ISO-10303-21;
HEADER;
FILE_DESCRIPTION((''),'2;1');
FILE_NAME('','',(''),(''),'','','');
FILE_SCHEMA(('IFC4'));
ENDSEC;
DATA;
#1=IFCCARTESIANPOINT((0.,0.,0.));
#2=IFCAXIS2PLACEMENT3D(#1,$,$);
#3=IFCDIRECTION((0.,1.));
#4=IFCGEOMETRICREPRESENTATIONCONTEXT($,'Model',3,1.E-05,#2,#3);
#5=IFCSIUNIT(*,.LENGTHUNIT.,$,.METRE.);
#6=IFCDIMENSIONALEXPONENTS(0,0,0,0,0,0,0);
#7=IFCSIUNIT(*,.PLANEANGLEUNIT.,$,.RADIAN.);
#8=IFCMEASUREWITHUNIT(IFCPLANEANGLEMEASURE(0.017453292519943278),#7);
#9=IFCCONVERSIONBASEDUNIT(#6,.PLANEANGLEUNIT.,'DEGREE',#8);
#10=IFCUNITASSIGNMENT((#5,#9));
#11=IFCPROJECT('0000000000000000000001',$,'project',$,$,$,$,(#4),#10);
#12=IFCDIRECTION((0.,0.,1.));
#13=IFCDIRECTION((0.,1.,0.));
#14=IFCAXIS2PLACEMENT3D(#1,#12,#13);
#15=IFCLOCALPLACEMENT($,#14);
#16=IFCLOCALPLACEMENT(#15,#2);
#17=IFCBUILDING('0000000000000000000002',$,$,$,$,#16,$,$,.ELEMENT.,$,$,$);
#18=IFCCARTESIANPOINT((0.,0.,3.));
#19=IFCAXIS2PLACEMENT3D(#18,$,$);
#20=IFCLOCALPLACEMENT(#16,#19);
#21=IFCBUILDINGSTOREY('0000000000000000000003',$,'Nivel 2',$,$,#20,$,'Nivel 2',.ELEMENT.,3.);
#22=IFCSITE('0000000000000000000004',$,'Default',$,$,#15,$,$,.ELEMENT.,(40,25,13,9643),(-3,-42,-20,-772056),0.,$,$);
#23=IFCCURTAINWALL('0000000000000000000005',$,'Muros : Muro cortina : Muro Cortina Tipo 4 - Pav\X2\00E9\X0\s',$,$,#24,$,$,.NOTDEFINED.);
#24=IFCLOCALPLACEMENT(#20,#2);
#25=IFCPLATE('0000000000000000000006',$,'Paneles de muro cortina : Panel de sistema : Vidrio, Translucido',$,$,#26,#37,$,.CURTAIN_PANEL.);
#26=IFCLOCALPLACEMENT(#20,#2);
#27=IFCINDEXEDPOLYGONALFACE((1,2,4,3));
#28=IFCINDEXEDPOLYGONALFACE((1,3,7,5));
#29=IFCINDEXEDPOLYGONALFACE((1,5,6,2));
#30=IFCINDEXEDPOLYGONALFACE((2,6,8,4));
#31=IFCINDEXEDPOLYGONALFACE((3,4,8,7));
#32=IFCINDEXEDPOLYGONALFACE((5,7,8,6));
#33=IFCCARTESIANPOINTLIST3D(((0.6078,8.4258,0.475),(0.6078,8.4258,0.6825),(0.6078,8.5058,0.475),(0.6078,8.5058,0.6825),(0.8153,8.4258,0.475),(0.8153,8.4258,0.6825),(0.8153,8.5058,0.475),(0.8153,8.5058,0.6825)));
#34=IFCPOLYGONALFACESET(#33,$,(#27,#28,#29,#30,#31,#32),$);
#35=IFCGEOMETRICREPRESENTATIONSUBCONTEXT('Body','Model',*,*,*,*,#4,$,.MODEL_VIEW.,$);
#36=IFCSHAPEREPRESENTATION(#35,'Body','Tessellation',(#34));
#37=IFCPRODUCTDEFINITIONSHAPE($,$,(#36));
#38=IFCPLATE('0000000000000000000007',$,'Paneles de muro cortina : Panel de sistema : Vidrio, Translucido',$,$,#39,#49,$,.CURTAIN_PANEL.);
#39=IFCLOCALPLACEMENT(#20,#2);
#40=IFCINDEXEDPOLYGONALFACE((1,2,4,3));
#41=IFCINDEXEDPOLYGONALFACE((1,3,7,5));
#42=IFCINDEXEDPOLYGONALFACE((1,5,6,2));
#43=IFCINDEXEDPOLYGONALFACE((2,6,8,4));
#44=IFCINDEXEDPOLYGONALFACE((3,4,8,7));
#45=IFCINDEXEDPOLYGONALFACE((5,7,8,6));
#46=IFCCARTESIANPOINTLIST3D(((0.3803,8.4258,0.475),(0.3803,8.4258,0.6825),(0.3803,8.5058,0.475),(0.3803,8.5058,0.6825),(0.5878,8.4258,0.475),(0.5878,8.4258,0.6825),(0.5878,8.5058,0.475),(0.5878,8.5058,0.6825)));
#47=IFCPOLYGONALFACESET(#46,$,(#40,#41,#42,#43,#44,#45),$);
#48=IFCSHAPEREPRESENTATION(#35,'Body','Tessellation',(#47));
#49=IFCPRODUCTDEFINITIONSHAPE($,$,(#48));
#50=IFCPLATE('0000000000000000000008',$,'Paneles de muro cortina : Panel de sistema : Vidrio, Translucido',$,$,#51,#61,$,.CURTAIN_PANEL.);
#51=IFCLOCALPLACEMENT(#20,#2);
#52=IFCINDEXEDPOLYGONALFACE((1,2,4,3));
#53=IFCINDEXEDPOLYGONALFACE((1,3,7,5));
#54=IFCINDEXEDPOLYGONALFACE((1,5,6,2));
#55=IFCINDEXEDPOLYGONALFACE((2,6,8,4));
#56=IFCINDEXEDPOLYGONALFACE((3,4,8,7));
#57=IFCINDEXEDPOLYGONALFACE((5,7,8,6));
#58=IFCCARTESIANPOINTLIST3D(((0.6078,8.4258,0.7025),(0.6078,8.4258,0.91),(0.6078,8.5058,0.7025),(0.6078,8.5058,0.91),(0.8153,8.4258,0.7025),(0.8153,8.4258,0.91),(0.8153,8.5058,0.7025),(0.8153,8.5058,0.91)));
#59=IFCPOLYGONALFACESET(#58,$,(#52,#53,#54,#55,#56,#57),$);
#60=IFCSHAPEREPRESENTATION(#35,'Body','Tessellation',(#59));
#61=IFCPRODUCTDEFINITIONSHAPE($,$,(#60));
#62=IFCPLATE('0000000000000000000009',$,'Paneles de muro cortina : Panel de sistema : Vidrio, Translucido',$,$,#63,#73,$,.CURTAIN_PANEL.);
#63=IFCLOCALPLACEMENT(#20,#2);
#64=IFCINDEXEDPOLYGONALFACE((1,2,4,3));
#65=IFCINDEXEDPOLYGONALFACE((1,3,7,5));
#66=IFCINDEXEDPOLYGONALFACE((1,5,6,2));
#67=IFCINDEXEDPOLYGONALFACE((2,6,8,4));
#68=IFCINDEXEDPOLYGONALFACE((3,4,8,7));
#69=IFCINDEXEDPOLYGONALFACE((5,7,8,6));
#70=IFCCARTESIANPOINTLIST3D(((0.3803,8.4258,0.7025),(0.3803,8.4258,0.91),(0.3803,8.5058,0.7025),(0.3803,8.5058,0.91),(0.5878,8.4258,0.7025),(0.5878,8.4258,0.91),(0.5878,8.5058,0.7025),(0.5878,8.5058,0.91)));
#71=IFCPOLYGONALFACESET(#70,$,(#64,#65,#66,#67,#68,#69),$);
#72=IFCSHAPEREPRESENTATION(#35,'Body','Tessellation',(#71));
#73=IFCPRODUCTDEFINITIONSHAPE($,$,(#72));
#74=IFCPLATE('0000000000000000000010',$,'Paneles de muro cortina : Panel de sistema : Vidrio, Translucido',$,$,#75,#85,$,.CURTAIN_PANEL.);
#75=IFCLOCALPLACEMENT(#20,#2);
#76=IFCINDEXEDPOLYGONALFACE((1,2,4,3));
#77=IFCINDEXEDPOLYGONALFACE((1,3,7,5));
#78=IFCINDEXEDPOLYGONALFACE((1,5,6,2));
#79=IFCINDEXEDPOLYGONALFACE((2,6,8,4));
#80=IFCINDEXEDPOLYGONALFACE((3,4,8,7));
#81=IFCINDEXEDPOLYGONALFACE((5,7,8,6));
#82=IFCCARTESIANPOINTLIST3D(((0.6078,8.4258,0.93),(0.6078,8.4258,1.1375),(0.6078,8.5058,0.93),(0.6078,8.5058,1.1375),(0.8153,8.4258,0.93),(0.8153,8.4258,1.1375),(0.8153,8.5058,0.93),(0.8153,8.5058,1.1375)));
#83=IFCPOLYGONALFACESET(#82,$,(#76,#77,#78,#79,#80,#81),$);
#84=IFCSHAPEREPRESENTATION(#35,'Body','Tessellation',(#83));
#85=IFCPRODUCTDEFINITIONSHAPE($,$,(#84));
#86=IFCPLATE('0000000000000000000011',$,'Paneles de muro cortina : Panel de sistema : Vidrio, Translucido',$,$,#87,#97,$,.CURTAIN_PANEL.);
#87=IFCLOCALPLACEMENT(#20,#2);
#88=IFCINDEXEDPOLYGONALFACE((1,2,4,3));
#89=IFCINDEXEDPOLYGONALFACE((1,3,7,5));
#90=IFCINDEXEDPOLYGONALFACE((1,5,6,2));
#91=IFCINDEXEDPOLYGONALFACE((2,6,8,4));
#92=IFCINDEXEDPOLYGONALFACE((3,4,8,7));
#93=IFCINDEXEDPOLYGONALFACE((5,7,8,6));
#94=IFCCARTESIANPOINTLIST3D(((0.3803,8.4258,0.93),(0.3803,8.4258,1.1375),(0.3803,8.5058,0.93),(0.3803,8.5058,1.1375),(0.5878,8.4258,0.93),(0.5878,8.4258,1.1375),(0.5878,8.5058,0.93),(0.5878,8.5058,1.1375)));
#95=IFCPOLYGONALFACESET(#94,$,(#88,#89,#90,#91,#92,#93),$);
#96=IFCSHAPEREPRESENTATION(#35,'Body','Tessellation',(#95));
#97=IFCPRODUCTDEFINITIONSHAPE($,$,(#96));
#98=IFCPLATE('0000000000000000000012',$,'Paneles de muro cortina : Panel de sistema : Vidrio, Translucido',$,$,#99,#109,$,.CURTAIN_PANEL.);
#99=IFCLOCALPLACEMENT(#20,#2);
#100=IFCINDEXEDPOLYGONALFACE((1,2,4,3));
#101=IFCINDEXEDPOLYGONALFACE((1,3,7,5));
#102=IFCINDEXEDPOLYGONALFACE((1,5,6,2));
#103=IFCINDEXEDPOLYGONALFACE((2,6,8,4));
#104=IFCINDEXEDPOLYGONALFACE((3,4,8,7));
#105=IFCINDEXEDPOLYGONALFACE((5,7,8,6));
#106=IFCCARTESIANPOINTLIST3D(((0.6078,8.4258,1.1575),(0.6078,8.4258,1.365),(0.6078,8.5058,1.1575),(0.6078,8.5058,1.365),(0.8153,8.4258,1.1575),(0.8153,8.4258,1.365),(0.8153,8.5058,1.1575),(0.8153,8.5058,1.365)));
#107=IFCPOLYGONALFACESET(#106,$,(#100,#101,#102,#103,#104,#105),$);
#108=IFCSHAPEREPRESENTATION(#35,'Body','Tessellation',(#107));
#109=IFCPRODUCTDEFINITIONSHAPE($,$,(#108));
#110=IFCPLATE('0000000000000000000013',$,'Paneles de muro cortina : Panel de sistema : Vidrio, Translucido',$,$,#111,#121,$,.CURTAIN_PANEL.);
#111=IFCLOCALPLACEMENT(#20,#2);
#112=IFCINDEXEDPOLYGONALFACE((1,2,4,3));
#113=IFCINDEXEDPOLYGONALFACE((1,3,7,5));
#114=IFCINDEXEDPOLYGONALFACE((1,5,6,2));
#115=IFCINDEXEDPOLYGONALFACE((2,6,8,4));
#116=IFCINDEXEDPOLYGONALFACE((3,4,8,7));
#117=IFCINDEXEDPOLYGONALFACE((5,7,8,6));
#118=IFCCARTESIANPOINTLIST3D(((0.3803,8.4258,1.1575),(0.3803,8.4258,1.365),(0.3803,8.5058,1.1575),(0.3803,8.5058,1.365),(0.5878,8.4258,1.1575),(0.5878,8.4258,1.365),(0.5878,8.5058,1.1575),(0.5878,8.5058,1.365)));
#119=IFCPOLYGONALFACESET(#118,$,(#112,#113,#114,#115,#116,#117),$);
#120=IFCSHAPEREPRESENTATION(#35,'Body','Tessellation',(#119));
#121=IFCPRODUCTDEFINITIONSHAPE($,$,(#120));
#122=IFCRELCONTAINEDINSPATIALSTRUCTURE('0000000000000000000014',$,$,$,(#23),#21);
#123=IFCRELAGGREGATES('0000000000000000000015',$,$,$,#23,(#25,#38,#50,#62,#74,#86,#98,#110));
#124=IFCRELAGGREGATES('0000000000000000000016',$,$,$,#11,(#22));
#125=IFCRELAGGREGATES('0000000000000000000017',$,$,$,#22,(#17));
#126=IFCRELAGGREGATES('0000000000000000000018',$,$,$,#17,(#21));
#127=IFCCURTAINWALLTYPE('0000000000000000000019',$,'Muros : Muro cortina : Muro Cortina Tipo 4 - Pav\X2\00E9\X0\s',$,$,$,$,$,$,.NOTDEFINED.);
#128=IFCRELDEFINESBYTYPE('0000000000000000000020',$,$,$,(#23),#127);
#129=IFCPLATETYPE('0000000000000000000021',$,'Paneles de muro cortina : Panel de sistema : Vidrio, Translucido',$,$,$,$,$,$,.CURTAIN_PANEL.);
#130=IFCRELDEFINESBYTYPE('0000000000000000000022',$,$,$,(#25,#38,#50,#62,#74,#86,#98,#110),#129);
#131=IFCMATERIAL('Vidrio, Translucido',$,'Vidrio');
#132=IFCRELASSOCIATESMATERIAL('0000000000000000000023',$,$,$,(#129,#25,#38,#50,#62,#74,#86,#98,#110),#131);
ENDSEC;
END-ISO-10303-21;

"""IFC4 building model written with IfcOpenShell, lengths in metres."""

from ifc_helpers import new_model, entity, si_unit, converted_unit, direction, frame, origin, place, context, subcontext, project, spatial, indexed_curve, outline, extrude, source, transform, mapped, material, type_object, type_shapes, element, aggregate, save


model = new_model("IFC4")

# Units and contexts
model_context = context("Model", 3, precision=1e-05, world=origin(), true_north=direction((0.0, 1.0)))
body_context = subcontext(model_context, "Body", "Model", "MODEL_VIEW")
ifc_project = project(units=[si_unit("LENGTHUNIT", "METRE"), converted_unit("PLANEANGLEUNIT", "DEGREE", entity("IfcPlaneAngleMeasure", 0.017453292519943278), si_unit("PLANEANGLEUNIT", "RADIAN"), dimensions=[0, 0, 0, 0, 0, 0, 0])], contexts=[model_context])

# Site, building, storey
site_placement = place(None, frame((0.0, 0.0, 0.0), z_axis=(0.0, 0.0, 1.0), x_axis=(0.0, 1.0, 0.0)))
site = spatial("IfcSite", under=ifc_project, at=site_placement, Name="Default", CompositionType="ELEMENT", RefLatitude=(40, 25, 13, 9643), RefLongitude=(-3, -42, -20, -772056), RefElevation=0.0)
building_placement = place(site_placement, origin())
building = spatial("IfcBuilding", under=site, at=building_placement, CompositionType="ELEMENT")
storey_placement = place(building_placement, frame((0.0, 0.0, 3.0)))
storey = spatial("IfcBuildingStorey", under=building, at=storey_placement, Name="Nivel 2", LongName="Nivel 2", CompositionType="ELEMENT", Elevation=3.0)

# Curtain wall, plates
curtain_wall_type = type_object("IfcCurtainWallType", Name="Muros : Muro cortina : Muro Cortina Tipo 4 - Pavés", PredefinedType="NOTDEFINED")
curtain_wall_placement = place(storey_placement, frame((0.0, 0.0, -3.0)))
curtain_wall = element("IfcCurtainWall", 1, at=curtain_wall_placement, inside=storey, type_object=curtain_wall_type, Name="Muros : Muro cortina : Muro Cortina Tipo 4 - Pavés", PredefinedType="NOTDEFINED")
ifc_material_1 = material(Name="Vidrio, Translucido", Category="Vidrio")
plate_type = type_object("IfcPlateType", Name="Paneles de muro cortina : Panel de sistema : Vidrio, Translucido", PredefinedType="CURTAIN_PANEL", material=ifc_material_1)
shared_shape_1 = source(origin(), body_context, "Body", "SweptSolid", [
    extrude(outline(indexed_curve([(-0.04, -0.1038), (0.04, -0.1038), (0.04, 0.1038), (-0.04, 0.1038), (-0.04, -0.1038)], self_intersect=False)), frame((0.0, 0.0, 0.0), z_axis=(0.0, 0.0, 1.0), x_axis=(0.0, 1.0, 0.0)), (0.0, 0.0, 1.0), 0.2075),
])
type_shapes(plate_type, [shared_shape_1])
plate_1_placement = place(curtain_wall_placement, frame((0.7115, 8.4658, 3.475), z_axis=(0.0, 0.0, 1.0), x_axis=(-1.0, 0.0, 0.0)))
plate_1 = element("IfcPlate", 2, at=plate_1_placement, type_object=plate_type, material=ifc_material_1, Name="Paneles de muro cortina : Panel de sistema : Vidrio, Translucido", PredefinedType="CURTAIN_PANEL", context=body_context, shape_type="MappedRepresentation", body=[
    mapped(shared_shape_1, transform((0.0, 0.0, 0.0), scale=1.0)),
])
plate_2_placement = place(curtain_wall_placement, frame((0.484, 8.4658, 3.475), z_axis=(0.0, 0.0, 1.0), x_axis=(-1.0, 0.0, 0.0)))
plate_2 = element("IfcPlate", 3, at=plate_2_placement, type_object=plate_type, material=ifc_material_1, Name="Paneles de muro cortina : Panel de sistema : Vidrio, Translucido", PredefinedType="CURTAIN_PANEL", context=body_context, shape_type="MappedRepresentation", body=[
    mapped(shared_shape_1, transform((0.0, 0.0, 0.0), scale=1.0)),
])
plate_3_placement = place(curtain_wall_placement, frame((0.7115, 8.4658, 3.7025), z_axis=(0.0, 0.0, 1.0), x_axis=(-1.0, 0.0, 0.0)))
plate_3 = element("IfcPlate", 4, at=plate_3_placement, type_object=plate_type, material=ifc_material_1, Name="Paneles de muro cortina : Panel de sistema : Vidrio, Translucido", PredefinedType="CURTAIN_PANEL", context=body_context, shape_type="MappedRepresentation", body=[
    mapped(shared_shape_1, transform((0.0, 0.0, 0.0), scale=1.0)),
])
plate_4_placement = place(curtain_wall_placement, frame((0.484, 8.4658, 3.7025), z_axis=(0.0, 0.0, 1.0), x_axis=(-1.0, 0.0, 0.0)))
plate_4 = element("IfcPlate", 5, at=plate_4_placement, type_object=plate_type, material=ifc_material_1, Name="Paneles de muro cortina : Panel de sistema : Vidrio, Translucido", PredefinedType="CURTAIN_PANEL", context=body_context, shape_type="MappedRepresentation", body=[
    mapped(shared_shape_1, transform((0.0, 0.0, 0.0), scale=1.0)),
])
plate_5_placement = place(curtain_wall_placement, frame((0.7115, 8.4658, 3.93), z_axis=(0.0, 0.0, 1.0), x_axis=(-1.0, 0.0, 0.0)))
plate_5 = element("IfcPlate", 6, at=plate_5_placement, type_object=plate_type, material=ifc_material_1, Name="Paneles de muro cortina : Panel de sistema : Vidrio, Translucido", PredefinedType="CURTAIN_PANEL", context=body_context, shape_type="MappedRepresentation", body=[
    mapped(shared_shape_1, transform((0.0, 0.0, 0.0), scale=1.0)),
])
plate_6_placement = place(curtain_wall_placement, frame((0.484, 8.4658, 3.93), z_axis=(0.0, 0.0, 1.0), x_axis=(-1.0, 0.0, 0.0)))
plate_6 = element("IfcPlate", 7, at=plate_6_placement, type_object=plate_type, material=ifc_material_1, Name="Paneles de muro cortina : Panel de sistema : Vidrio, Translucido", PredefinedType="CURTAIN_PANEL", context=body_context, shape_type="MappedRepresentation", body=[
    mapped(shared_shape_1, transform((0.0, 0.0, 0.0), scale=1.0)),
])
plate_7_placement = place(curtain_wall_placement, frame((0.7115, 8.4658, 4.1575), z_axis=(0.0, 0.0, 1.0), x_axis=(-1.0, 0.0, 0.0)))
plate_7 = element("IfcPlate", 8, at=plate_7_placement, type_object=plate_type, material=ifc_material_1, Name="Paneles de muro cortina : Panel de sistema : Vidrio, Translucido", PredefinedType="CURTAIN_PANEL", context=body_context, shape_type="MappedRepresentation", body=[
    mapped(shared_shape_1, transform((0.0, 0.0, 0.0), scale=1.0)),
])
plate_8_placement = place(curtain_wall_placement, frame((0.484, 8.4658, 4.1575), z_axis=(0.0, 0.0, 1.0), x_axis=(-1.0, 0.0, 0.0)))
plate_8 = element("IfcPlate", 9, at=plate_8_placement, type_object=plate_type, material=ifc_material_1, Name="Paneles de muro cortina : Panel de sistema : Vidrio, Translucido", PredefinedType="CURTAIN_PANEL", context=body_context, shape_type="MappedRepresentation", body=[
    mapped(shared_shape_1, transform((0.0, 0.0, 0.0), scale=1.0)),
])
aggregate(curtain_wall, [plate_1, plate_2, plate_3, plate_4, plate_5, plate_6, plate_7, plate_8])

save(model, "model.ifc")
